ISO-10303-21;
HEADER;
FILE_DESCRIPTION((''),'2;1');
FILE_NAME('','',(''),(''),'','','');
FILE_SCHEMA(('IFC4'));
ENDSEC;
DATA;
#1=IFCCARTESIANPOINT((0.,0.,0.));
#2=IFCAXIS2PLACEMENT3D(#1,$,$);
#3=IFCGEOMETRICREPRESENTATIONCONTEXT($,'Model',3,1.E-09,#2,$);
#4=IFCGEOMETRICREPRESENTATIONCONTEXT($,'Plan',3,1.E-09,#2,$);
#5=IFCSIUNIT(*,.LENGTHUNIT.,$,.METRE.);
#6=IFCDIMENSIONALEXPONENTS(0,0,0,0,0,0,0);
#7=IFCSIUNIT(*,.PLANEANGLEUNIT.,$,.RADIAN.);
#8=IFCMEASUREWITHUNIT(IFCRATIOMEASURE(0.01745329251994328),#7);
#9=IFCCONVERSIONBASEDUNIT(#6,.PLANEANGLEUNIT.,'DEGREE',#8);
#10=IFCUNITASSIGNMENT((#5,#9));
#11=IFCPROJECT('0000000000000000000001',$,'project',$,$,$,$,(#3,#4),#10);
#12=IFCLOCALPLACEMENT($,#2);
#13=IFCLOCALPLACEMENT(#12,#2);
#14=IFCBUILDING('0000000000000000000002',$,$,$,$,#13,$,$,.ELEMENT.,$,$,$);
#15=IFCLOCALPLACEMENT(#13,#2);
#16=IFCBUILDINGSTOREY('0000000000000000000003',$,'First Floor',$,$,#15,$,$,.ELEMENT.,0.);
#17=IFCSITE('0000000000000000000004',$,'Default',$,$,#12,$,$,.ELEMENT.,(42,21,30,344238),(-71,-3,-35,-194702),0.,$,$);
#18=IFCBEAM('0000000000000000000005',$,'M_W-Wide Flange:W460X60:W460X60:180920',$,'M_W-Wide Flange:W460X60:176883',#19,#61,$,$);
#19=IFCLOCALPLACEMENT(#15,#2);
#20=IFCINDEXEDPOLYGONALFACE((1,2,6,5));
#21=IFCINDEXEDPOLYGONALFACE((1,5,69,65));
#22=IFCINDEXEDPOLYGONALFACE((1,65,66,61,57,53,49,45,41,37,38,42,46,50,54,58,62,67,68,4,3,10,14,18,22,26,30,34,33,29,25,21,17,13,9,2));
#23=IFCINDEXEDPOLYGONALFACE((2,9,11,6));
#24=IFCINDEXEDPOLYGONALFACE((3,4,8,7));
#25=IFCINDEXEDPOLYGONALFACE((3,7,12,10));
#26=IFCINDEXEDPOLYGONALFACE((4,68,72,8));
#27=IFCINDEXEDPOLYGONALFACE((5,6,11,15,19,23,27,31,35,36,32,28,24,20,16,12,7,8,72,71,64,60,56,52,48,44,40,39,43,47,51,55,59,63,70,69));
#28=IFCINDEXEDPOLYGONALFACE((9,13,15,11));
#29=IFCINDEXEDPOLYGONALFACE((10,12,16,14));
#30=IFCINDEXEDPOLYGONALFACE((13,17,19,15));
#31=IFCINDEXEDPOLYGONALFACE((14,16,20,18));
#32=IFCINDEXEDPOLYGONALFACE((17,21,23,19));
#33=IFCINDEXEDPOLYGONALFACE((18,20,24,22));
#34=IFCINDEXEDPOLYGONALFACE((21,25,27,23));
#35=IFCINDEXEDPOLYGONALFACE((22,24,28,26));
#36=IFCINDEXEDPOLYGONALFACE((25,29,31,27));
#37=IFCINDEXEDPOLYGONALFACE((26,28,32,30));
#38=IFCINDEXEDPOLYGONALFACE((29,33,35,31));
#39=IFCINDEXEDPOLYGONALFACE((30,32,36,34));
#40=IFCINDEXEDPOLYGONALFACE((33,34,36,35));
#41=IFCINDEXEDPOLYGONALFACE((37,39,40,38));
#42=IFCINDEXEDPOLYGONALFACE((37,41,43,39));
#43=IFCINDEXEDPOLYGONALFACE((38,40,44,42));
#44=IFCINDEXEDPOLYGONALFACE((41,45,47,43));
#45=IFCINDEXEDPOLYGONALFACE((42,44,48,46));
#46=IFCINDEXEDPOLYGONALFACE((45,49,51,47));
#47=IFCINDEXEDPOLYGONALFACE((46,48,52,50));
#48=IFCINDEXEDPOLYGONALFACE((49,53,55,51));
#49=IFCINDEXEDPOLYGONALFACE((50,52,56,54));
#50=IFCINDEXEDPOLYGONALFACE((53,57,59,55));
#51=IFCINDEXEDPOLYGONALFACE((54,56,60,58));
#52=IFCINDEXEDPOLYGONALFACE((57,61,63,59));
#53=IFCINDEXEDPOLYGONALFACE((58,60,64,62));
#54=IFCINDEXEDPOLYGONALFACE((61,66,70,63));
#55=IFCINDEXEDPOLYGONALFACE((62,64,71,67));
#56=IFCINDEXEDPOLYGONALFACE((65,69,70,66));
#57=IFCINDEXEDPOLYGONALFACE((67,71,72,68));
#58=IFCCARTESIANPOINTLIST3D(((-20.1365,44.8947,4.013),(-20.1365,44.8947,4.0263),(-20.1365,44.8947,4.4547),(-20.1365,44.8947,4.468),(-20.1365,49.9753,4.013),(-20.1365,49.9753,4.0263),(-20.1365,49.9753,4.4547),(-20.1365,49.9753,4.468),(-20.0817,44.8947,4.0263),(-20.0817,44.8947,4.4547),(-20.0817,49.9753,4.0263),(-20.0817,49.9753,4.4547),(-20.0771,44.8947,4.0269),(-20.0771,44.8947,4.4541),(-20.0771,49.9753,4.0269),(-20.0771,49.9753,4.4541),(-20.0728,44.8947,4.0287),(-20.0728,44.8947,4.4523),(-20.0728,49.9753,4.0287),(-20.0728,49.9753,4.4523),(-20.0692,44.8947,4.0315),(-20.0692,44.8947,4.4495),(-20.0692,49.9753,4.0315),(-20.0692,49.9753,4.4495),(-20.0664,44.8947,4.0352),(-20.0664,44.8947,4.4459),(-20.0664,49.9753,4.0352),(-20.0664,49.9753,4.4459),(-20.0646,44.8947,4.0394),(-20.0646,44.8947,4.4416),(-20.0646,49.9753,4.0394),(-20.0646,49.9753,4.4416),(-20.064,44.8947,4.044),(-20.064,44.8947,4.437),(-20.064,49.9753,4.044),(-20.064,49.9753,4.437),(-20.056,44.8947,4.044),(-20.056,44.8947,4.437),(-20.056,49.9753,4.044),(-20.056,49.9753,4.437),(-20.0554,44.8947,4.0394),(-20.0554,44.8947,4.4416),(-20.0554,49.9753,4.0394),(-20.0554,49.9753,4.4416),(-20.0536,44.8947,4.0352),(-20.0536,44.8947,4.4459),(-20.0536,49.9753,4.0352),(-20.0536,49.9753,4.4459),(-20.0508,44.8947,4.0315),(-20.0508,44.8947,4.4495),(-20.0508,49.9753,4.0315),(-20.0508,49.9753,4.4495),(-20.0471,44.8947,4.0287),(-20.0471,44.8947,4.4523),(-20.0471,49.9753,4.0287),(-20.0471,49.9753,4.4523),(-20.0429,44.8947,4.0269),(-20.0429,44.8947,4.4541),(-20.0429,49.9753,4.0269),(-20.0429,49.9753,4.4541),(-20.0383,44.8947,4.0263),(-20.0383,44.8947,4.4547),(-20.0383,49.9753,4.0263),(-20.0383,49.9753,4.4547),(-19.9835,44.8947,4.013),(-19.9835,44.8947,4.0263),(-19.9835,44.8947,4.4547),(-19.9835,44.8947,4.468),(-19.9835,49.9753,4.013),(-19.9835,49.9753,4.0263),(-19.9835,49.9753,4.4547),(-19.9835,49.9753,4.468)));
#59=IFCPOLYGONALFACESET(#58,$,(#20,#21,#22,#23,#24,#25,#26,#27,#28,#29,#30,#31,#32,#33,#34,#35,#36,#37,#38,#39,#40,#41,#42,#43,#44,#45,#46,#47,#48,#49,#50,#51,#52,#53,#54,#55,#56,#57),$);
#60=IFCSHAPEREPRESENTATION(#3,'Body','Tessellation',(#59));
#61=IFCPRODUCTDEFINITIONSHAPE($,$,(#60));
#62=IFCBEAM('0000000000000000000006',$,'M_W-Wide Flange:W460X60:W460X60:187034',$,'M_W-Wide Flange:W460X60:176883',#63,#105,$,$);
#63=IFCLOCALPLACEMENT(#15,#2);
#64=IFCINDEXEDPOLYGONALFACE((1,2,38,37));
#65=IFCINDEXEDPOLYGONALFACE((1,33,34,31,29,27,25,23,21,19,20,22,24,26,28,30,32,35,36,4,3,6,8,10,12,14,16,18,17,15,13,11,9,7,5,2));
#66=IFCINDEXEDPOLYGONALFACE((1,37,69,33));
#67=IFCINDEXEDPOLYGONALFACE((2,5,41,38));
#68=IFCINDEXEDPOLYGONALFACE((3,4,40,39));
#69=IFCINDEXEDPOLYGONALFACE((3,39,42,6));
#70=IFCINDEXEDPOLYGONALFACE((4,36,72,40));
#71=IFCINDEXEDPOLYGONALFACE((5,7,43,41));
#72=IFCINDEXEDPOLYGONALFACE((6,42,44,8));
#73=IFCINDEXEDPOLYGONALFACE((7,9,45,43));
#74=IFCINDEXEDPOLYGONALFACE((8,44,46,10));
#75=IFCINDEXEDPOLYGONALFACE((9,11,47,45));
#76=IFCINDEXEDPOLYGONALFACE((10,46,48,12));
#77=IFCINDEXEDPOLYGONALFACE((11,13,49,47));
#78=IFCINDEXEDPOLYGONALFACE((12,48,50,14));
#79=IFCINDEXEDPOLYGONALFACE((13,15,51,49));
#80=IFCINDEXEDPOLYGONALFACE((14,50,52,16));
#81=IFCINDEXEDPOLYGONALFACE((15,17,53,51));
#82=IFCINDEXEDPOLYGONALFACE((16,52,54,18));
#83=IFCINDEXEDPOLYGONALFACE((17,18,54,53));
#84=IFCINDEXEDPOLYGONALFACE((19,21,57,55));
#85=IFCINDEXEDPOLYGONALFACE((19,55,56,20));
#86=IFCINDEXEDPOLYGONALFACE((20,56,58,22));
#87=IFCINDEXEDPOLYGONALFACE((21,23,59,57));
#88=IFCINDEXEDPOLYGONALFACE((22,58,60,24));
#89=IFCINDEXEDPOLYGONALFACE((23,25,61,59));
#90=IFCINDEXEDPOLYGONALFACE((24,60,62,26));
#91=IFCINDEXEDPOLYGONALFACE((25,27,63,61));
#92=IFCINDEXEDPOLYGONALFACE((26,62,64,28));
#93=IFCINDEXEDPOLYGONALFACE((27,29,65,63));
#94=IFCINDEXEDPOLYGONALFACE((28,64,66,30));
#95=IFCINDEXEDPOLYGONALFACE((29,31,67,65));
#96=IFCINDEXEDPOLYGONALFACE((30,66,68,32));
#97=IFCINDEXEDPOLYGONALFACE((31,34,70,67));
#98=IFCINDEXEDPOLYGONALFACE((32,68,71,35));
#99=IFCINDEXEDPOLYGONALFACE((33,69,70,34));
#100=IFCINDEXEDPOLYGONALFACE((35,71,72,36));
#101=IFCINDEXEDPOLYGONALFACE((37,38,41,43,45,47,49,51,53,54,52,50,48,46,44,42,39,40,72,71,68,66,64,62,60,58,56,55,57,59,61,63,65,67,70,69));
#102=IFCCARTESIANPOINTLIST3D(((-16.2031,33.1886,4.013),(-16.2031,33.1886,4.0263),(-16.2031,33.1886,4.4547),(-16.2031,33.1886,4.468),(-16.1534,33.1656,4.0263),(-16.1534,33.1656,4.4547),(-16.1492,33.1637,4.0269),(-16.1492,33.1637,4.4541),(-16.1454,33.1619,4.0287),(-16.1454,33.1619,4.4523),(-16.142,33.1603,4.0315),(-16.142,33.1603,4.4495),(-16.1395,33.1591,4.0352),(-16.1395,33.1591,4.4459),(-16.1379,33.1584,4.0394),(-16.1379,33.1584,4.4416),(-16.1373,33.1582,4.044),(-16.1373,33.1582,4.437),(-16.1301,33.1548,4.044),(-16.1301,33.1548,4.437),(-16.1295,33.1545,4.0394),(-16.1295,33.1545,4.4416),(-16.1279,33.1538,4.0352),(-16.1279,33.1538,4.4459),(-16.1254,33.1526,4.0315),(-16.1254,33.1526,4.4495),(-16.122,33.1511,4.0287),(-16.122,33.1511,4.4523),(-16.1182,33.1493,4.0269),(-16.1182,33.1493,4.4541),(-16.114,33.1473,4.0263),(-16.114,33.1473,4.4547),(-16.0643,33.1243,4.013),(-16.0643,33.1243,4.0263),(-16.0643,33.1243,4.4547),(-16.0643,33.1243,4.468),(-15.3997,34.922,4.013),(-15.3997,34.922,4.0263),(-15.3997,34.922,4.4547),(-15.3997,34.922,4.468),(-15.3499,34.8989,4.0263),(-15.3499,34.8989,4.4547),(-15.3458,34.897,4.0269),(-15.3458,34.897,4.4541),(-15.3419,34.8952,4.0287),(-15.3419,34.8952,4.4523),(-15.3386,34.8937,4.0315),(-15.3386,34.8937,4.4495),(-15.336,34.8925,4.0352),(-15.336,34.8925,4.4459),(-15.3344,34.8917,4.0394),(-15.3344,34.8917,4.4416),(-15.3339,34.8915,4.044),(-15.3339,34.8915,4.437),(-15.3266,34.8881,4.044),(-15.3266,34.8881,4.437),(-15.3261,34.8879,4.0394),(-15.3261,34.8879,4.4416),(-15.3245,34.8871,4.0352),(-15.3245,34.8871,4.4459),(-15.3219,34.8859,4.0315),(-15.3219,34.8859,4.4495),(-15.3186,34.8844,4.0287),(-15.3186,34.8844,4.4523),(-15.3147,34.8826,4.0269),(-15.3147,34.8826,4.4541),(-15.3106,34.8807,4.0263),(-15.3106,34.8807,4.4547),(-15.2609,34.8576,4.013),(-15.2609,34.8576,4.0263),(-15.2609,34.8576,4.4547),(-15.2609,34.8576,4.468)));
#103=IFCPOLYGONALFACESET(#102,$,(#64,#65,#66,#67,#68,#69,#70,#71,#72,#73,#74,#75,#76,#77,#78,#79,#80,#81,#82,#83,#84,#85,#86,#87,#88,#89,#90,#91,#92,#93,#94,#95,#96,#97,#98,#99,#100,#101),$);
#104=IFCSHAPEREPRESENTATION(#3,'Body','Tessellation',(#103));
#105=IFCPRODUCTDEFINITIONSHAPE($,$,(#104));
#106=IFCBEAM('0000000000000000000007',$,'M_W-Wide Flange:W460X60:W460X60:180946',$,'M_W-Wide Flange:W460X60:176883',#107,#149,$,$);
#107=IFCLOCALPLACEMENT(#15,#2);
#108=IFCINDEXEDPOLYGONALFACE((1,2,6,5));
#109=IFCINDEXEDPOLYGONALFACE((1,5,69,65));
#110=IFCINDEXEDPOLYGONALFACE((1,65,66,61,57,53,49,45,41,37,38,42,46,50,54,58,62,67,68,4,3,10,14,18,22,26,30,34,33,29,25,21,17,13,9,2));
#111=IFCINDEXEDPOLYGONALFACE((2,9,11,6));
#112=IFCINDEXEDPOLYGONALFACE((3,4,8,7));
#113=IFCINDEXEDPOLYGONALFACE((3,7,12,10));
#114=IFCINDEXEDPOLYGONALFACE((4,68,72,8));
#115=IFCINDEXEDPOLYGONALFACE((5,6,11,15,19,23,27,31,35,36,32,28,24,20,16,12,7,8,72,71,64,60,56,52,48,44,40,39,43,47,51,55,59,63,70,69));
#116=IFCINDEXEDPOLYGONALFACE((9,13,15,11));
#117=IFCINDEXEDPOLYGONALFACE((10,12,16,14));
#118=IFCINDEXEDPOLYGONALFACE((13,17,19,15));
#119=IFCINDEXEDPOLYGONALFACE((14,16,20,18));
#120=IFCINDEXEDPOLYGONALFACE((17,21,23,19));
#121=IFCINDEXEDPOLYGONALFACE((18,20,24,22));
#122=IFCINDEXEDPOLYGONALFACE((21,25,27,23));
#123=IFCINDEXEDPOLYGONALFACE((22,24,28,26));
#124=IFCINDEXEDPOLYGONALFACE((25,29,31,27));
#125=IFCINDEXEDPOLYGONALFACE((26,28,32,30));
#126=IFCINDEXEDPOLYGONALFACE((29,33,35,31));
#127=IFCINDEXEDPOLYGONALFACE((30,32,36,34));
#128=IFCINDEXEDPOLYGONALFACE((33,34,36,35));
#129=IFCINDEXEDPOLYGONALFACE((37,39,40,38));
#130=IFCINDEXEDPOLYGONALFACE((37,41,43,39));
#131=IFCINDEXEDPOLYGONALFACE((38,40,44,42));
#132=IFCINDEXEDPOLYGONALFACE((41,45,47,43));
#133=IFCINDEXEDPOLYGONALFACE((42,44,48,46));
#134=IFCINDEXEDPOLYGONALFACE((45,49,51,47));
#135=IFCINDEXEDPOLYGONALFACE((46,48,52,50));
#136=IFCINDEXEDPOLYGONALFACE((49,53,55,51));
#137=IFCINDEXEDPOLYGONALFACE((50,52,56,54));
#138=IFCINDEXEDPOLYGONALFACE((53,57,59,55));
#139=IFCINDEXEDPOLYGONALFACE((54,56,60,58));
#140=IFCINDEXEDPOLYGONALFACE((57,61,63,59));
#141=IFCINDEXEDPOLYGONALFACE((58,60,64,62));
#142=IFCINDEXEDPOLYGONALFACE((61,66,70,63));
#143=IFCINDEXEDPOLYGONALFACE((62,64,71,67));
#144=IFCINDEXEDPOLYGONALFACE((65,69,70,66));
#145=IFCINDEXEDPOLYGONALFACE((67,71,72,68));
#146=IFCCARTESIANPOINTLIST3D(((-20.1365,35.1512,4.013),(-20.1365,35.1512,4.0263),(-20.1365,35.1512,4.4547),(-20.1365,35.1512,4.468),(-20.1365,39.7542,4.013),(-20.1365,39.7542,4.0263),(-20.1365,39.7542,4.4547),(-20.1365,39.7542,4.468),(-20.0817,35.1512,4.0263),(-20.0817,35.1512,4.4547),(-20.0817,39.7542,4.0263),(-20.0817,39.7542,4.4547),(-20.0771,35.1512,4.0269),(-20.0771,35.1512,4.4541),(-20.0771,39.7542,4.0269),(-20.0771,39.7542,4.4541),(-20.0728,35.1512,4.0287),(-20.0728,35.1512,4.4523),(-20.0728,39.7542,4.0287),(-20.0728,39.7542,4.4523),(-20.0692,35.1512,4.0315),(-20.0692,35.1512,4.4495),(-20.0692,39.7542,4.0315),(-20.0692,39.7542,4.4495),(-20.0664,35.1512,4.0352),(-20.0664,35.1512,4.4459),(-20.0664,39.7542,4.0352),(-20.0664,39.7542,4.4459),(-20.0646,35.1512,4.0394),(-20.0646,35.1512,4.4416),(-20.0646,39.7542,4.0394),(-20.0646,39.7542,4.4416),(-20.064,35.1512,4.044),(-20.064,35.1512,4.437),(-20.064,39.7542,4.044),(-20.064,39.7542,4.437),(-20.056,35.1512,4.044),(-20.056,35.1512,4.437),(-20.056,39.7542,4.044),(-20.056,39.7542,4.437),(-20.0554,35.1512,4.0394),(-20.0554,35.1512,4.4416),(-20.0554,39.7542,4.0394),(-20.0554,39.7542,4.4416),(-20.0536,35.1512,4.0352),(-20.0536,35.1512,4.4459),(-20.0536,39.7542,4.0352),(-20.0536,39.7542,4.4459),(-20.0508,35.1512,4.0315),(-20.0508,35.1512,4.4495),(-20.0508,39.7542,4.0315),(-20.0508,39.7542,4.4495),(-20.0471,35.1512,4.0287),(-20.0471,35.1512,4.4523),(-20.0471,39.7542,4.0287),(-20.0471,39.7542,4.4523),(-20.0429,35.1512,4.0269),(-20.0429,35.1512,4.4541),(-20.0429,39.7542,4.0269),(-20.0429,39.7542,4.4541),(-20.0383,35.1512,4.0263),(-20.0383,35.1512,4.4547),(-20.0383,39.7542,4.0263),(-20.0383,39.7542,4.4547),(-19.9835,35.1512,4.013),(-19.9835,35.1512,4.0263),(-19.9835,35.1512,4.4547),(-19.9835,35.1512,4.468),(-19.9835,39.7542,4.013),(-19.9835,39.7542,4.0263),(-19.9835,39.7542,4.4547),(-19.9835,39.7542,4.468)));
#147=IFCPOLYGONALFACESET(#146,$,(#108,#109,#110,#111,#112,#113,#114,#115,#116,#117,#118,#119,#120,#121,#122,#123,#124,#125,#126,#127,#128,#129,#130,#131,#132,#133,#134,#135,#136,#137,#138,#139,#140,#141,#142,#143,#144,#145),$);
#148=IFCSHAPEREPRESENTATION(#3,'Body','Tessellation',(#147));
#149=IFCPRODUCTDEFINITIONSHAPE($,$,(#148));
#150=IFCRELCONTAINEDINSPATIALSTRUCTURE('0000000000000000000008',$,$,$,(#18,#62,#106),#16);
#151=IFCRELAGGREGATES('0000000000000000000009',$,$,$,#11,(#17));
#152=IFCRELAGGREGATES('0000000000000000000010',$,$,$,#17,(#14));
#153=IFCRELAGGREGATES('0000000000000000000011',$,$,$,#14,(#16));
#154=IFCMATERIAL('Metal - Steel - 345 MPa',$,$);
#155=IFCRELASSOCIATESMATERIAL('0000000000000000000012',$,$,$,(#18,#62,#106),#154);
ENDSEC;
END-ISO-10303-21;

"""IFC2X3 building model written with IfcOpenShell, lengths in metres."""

from ifc_helpers import new_model, entity, si_unit, converted_unit, frame, frame_2d, origin, place, context, project, spatial, polyline, circle_curve, parameter, trimmed, segment, composite_curve, outline, extrude, material, element, save


model = new_model("IFC2X3")

# Units and contexts
model_context = context("Model", 3, precision=1e-09, world=origin())
plan_context = context("Plan", 3, precision=1e-09, world=origin())
ifc_project = project(units=[si_unit("LENGTHUNIT", "METRE"), converted_unit("PLANEANGLEUNIT", "DEGREE", entity("IfcRatioMeasure", 0.01745329251994328), si_unit("PLANEANGLEUNIT", "RADIAN"), dimensions=[0, 0, 0, 0, 0, 0, 0])], contexts=[model_context, plan_context])

# Site, building, storey
site_placement = place(None, origin())
site = spatial("IfcSite", under=ifc_project, at=site_placement, Name="Default", CompositionType="ELEMENT", RefLatitude=(42, 21, 30, 344238), RefLongitude=(-71, -3, -35, -194702), RefElevation=0.0)
building_placement = place(site_placement, origin())
building = spatial("IfcBuilding", under=site, at=building_placement, CompositionType="ELEMENT")
storey_placement = place(building_placement, origin())
storey = spatial("IfcBuildingStorey", under=building, at=storey_placement, Name="First Floor", CompositionType="ELEMENT", Elevation=0.0)

# Shared definitions
ifc_material = material(Name="Metal - Steel - 345 MPa")

# Beams
beam_1_placement = place(storey_placement, frame((-20.06, 50.0926, 4.468), z_axis=(0.0, 0.0, 1.0), x_axis=(-1.0, 0.0, 0.0)))
element("IfcBeam", 1, at=beam_1_placement, inside=storey, material=ifc_material, Name="M_W-Wide Flange:W460X60:W460X60:180920", ObjectType="M_W-Wide Flange:W460X60:176883", context=model_context, shape_type="SweptSolid", body=[
    extrude(outline(composite_curve([segment(polyline([(0.2142, -0.0765), (0.2275, -0.0765)]), True, "CONTINUOUS"), segment(polyline([(0.2275, -0.0765), (0.2275, 0.0765)]), True, "CONTINUOUS"), segment(polyline([(0.2275, 0.0765), (0.2142, 0.0765)]), True, "CONTINUOUS"), segment(polyline([(0.2142, 0.0765), (0.2142, 0.0217)]), True, "CONTINUOUS"), segment(trimmed(circle_curve(frame_2d((0.1965, 0.0217), x_axis=(1.0, 0.0)), 0.0177), [parameter(270.0)], [parameter(360.0)], True, "PARAMETER"), False, "CONTINUOUS"), segment(polyline([(0.1965, 0.004), (-0.1965, 0.004)]), True, "CONTINUOUS"), segment(trimmed(circle_curve(frame_2d((-0.1965, 0.0217), x_axis=(0.0, -1.0)), 0.0177), [parameter(270.0)], [parameter(360.0)], True, "PARAMETER"), False, "CONTINUOUS"), segment(polyline([(-0.2142, 0.0217), (-0.2142, 0.0765)]), True, "CONTINUOUS"), segment(polyline([(-0.2142, 0.0765), (-0.2275, 0.0765)]), True, "CONTINUOUS"), segment(polyline([(-0.2275, 0.0765), (-0.2275, -0.0765)]), True, "CONTINUOUS"), segment(polyline([(-0.2275, -0.0765), (-0.2142, -0.0765)]), True, "CONTINUOUS"), segment(polyline([(-0.2142, -0.0765), (-0.2142, -0.0217)]), True, "CONTINUOUS"), segment(trimmed(circle_curve(frame_2d((-0.1965, -0.0217), x_axis=(-1.0, 0.0)), 0.0177), [parameter(270.0)], [parameter(360.0)], True, "PARAMETER"), False, "CONTINUOUS"), segment(polyline([(-0.1965, -0.004), (0.1965, -0.004)]), True, "CONTINUOUS"), segment(trimmed(circle_curve(frame_2d((0.1965, -0.0217), x_axis=(0.0, 1.0)), 0.0177), [parameter(270.0)], [parameter(0.0)], True, "PARAMETER"), False, "CONTINUOUS"), segment(polyline([(0.2142, -0.0217), (0.2142, -0.0765)]), True, "CONTINUOUS")], self_intersect=False)), frame((0.0, 5.1979, -0.2275), z_axis=(0.0, -1.0, 0.0), x_axis=(0.0, 0.0, -1.0)), (0.0, 0.0, 1.0), 5.0806),
])
beam_2_placement = place(storey_placement, frame((-16.2178, 32.975, 4.468), z_axis=(0.0, 0.0, 1.0), x_axis=(0.907271, -0.420546, 0.0)))
element("IfcBeam", 2, at=beam_2_placement, inside=storey, material=ifc_material, Name="M_W-Wide Flange:W460X60:W460X60:187034", ObjectType="M_W-Wide Flange:W460X60:176883", context=model_context, shape_type="SweptSolid", body=[
    extrude(outline(composite_curve([segment(polyline([(-0.0765, -0.2142), (-0.0765, -0.2275)]), True, "CONTINUOUS"), segment(polyline([(-0.0765, -0.2275), (0.0765, -0.2275)]), True, "CONTINUOUS"), segment(polyline([(0.0765, -0.2275), (0.0765, -0.2142)]), True, "CONTINUOUS"), segment(polyline([(0.0765, -0.2142), (0.0217, -0.2142)]), True, "CONTINUOUS"), segment(trimmed(circle_curve(frame_2d((0.0217, -0.1965), x_axis=(1.0, 0.0)), 0.0177), [parameter(180.0)], [parameter(270.0)], True, "PARAMETER"), False, "CONTINUOUS"), segment(polyline([(0.004, -0.1965), (0.004, 0.1965)]), True, "CONTINUOUS"), segment(trimmed(circle_curve(frame_2d((0.0217, 0.1965), x_axis=(1.0, 0.0)), 0.0177), [parameter(90.0)], [parameter(180.0)], True, "PARAMETER"), False, "CONTINUOUS"), segment(polyline([(0.0217, 0.2142), (0.0765, 0.2142)]), True, "CONTINUOUS"), segment(polyline([(0.0765, 0.2142), (0.0765, 0.2275)]), True, "CONTINUOUS"), segment(polyline([(0.0765, 0.2275), (-0.0765, 0.2275)]), True, "CONTINUOUS"), segment(polyline([(-0.0765, 0.2275), (-0.0765, 0.2142)]), True, "CONTINUOUS"), segment(polyline([(-0.0765, 0.2142), (-0.0217, 0.2142)]), True, "CONTINUOUS"), segment(trimmed(circle_curve(frame_2d((-0.0217, 0.1965), x_axis=(1.0, 0.0)), 0.0177), [parameter(360.0)], [parameter(90.0)], True, "PARAMETER"), False, "CONTINUOUS"), segment(polyline([(-0.004, 0.1965), (-0.004, -0.1965)]), True, "CONTINUOUS"), segment(trimmed(circle_curve(frame_2d((-0.0217, -0.1965), x_axis=(1.0, 0.0)), 0.0177), [parameter(270.0)], [parameter(0.0)], True, "PARAMETER"), False, "CONTINUOUS"), segment(polyline([(-0.0217, -0.2142), (-0.0765, -0.2142)]), True, "CONTINUOUS")], self_intersect=False)), frame((0.0, 0.2, -0.2275), z_axis=(0.0, -1.0, 0.0), x_axis=(1.0, 0.0, 0.0)), (0.0, 0.0, -1.0), 1.9105),
])
beam_3_placement = place(storey_placement, frame((-20.06, 39.8982, 4.468), z_axis=(0.0, 0.0, 1.0), x_axis=(-1.0, 0.0, 0.0)))
element("IfcBeam", 3, at=beam_3_placement, inside=storey, material=ifc_material, Name="M_W-Wide Flange:W460X60:W460X60:180946", ObjectType="M_W-Wide Flange:W460X60:176883", context=model_context, shape_type="SweptSolid", body=[
    extrude(outline(composite_curve([segment(polyline([(0.2142, -0.0765), (0.2275, -0.0765)]), True, "CONTINUOUS"), segment(polyline([(0.2275, -0.0765), (0.2275, 0.0765)]), True, "CONTINUOUS"), segment(polyline([(0.2275, 0.0765), (0.2142, 0.0765)]), True, "CONTINUOUS"), segment(polyline([(0.2142, 0.0765), (0.2142, 0.0217)]), True, "CONTINUOUS"), segment(trimmed(circle_curve(frame_2d((0.1965, 0.0217), x_axis=(1.0, 0.0)), 0.0177), [parameter(270.0)], [parameter(360.0)], True, "PARAMETER"), False, "CONTINUOUS"), segment(polyline([(0.1965, 0.004), (-0.1965, 0.004)]), True, "CONTINUOUS"), segment(trimmed(circle_curve(frame_2d((-0.1965, 0.0217), x_axis=(0.0, -1.0)), 0.0177), [parameter(270.0)], [parameter(360.0)], True, "PARAMETER"), False, "CONTINUOUS"), segment(polyline([(-0.2142, 0.0217), (-0.2142, 0.0765)]), True, "CONTINUOUS"), segment(polyline([(-0.2142, 0.0765), (-0.2275, 0.0765)]), True, "CONTINUOUS"), segment(polyline([(-0.2275, 0.0765), (-0.2275, -0.0765)]), True, "CONTINUOUS"), segment(polyline([(-0.2275, -0.0765), (-0.2142, -0.0765)]), True, "CONTINUOUS"), segment(polyline([(-0.2142, -0.0765), (-0.2142, -0.0217)]), True, "CONTINUOUS"), segment(trimmed(circle_curve(frame_2d((-0.1965, -0.0217), x_axis=(-1.0, 0.0)), 0.0177), [parameter(270.0)], [parameter(360.0)], True, "PARAMETER"), False, "CONTINUOUS"), segment(polyline([(-0.1965, -0.004), (0.1965, -0.004)]), True, "CONTINUOUS"), segment(trimmed(circle_curve(frame_2d((0.1965, -0.0217), x_axis=(0.0, 1.0)), 0.0177), [parameter(270.0)], [parameter(0.0)], True, "PARAMETER"), False, "CONTINUOUS"), segment(polyline([(0.2142, -0.0217), (0.2142, -0.0765)]), True, "CONTINUOUS")], self_intersect=False)), frame((0.0, 4.747, -0.2275), z_axis=(0.0, -1.0, 0.0), x_axis=(0.0, 0.0, -1.0)), (0.0, 0.0, 1.0), 4.603),
])

save(model, "model.ifc")
